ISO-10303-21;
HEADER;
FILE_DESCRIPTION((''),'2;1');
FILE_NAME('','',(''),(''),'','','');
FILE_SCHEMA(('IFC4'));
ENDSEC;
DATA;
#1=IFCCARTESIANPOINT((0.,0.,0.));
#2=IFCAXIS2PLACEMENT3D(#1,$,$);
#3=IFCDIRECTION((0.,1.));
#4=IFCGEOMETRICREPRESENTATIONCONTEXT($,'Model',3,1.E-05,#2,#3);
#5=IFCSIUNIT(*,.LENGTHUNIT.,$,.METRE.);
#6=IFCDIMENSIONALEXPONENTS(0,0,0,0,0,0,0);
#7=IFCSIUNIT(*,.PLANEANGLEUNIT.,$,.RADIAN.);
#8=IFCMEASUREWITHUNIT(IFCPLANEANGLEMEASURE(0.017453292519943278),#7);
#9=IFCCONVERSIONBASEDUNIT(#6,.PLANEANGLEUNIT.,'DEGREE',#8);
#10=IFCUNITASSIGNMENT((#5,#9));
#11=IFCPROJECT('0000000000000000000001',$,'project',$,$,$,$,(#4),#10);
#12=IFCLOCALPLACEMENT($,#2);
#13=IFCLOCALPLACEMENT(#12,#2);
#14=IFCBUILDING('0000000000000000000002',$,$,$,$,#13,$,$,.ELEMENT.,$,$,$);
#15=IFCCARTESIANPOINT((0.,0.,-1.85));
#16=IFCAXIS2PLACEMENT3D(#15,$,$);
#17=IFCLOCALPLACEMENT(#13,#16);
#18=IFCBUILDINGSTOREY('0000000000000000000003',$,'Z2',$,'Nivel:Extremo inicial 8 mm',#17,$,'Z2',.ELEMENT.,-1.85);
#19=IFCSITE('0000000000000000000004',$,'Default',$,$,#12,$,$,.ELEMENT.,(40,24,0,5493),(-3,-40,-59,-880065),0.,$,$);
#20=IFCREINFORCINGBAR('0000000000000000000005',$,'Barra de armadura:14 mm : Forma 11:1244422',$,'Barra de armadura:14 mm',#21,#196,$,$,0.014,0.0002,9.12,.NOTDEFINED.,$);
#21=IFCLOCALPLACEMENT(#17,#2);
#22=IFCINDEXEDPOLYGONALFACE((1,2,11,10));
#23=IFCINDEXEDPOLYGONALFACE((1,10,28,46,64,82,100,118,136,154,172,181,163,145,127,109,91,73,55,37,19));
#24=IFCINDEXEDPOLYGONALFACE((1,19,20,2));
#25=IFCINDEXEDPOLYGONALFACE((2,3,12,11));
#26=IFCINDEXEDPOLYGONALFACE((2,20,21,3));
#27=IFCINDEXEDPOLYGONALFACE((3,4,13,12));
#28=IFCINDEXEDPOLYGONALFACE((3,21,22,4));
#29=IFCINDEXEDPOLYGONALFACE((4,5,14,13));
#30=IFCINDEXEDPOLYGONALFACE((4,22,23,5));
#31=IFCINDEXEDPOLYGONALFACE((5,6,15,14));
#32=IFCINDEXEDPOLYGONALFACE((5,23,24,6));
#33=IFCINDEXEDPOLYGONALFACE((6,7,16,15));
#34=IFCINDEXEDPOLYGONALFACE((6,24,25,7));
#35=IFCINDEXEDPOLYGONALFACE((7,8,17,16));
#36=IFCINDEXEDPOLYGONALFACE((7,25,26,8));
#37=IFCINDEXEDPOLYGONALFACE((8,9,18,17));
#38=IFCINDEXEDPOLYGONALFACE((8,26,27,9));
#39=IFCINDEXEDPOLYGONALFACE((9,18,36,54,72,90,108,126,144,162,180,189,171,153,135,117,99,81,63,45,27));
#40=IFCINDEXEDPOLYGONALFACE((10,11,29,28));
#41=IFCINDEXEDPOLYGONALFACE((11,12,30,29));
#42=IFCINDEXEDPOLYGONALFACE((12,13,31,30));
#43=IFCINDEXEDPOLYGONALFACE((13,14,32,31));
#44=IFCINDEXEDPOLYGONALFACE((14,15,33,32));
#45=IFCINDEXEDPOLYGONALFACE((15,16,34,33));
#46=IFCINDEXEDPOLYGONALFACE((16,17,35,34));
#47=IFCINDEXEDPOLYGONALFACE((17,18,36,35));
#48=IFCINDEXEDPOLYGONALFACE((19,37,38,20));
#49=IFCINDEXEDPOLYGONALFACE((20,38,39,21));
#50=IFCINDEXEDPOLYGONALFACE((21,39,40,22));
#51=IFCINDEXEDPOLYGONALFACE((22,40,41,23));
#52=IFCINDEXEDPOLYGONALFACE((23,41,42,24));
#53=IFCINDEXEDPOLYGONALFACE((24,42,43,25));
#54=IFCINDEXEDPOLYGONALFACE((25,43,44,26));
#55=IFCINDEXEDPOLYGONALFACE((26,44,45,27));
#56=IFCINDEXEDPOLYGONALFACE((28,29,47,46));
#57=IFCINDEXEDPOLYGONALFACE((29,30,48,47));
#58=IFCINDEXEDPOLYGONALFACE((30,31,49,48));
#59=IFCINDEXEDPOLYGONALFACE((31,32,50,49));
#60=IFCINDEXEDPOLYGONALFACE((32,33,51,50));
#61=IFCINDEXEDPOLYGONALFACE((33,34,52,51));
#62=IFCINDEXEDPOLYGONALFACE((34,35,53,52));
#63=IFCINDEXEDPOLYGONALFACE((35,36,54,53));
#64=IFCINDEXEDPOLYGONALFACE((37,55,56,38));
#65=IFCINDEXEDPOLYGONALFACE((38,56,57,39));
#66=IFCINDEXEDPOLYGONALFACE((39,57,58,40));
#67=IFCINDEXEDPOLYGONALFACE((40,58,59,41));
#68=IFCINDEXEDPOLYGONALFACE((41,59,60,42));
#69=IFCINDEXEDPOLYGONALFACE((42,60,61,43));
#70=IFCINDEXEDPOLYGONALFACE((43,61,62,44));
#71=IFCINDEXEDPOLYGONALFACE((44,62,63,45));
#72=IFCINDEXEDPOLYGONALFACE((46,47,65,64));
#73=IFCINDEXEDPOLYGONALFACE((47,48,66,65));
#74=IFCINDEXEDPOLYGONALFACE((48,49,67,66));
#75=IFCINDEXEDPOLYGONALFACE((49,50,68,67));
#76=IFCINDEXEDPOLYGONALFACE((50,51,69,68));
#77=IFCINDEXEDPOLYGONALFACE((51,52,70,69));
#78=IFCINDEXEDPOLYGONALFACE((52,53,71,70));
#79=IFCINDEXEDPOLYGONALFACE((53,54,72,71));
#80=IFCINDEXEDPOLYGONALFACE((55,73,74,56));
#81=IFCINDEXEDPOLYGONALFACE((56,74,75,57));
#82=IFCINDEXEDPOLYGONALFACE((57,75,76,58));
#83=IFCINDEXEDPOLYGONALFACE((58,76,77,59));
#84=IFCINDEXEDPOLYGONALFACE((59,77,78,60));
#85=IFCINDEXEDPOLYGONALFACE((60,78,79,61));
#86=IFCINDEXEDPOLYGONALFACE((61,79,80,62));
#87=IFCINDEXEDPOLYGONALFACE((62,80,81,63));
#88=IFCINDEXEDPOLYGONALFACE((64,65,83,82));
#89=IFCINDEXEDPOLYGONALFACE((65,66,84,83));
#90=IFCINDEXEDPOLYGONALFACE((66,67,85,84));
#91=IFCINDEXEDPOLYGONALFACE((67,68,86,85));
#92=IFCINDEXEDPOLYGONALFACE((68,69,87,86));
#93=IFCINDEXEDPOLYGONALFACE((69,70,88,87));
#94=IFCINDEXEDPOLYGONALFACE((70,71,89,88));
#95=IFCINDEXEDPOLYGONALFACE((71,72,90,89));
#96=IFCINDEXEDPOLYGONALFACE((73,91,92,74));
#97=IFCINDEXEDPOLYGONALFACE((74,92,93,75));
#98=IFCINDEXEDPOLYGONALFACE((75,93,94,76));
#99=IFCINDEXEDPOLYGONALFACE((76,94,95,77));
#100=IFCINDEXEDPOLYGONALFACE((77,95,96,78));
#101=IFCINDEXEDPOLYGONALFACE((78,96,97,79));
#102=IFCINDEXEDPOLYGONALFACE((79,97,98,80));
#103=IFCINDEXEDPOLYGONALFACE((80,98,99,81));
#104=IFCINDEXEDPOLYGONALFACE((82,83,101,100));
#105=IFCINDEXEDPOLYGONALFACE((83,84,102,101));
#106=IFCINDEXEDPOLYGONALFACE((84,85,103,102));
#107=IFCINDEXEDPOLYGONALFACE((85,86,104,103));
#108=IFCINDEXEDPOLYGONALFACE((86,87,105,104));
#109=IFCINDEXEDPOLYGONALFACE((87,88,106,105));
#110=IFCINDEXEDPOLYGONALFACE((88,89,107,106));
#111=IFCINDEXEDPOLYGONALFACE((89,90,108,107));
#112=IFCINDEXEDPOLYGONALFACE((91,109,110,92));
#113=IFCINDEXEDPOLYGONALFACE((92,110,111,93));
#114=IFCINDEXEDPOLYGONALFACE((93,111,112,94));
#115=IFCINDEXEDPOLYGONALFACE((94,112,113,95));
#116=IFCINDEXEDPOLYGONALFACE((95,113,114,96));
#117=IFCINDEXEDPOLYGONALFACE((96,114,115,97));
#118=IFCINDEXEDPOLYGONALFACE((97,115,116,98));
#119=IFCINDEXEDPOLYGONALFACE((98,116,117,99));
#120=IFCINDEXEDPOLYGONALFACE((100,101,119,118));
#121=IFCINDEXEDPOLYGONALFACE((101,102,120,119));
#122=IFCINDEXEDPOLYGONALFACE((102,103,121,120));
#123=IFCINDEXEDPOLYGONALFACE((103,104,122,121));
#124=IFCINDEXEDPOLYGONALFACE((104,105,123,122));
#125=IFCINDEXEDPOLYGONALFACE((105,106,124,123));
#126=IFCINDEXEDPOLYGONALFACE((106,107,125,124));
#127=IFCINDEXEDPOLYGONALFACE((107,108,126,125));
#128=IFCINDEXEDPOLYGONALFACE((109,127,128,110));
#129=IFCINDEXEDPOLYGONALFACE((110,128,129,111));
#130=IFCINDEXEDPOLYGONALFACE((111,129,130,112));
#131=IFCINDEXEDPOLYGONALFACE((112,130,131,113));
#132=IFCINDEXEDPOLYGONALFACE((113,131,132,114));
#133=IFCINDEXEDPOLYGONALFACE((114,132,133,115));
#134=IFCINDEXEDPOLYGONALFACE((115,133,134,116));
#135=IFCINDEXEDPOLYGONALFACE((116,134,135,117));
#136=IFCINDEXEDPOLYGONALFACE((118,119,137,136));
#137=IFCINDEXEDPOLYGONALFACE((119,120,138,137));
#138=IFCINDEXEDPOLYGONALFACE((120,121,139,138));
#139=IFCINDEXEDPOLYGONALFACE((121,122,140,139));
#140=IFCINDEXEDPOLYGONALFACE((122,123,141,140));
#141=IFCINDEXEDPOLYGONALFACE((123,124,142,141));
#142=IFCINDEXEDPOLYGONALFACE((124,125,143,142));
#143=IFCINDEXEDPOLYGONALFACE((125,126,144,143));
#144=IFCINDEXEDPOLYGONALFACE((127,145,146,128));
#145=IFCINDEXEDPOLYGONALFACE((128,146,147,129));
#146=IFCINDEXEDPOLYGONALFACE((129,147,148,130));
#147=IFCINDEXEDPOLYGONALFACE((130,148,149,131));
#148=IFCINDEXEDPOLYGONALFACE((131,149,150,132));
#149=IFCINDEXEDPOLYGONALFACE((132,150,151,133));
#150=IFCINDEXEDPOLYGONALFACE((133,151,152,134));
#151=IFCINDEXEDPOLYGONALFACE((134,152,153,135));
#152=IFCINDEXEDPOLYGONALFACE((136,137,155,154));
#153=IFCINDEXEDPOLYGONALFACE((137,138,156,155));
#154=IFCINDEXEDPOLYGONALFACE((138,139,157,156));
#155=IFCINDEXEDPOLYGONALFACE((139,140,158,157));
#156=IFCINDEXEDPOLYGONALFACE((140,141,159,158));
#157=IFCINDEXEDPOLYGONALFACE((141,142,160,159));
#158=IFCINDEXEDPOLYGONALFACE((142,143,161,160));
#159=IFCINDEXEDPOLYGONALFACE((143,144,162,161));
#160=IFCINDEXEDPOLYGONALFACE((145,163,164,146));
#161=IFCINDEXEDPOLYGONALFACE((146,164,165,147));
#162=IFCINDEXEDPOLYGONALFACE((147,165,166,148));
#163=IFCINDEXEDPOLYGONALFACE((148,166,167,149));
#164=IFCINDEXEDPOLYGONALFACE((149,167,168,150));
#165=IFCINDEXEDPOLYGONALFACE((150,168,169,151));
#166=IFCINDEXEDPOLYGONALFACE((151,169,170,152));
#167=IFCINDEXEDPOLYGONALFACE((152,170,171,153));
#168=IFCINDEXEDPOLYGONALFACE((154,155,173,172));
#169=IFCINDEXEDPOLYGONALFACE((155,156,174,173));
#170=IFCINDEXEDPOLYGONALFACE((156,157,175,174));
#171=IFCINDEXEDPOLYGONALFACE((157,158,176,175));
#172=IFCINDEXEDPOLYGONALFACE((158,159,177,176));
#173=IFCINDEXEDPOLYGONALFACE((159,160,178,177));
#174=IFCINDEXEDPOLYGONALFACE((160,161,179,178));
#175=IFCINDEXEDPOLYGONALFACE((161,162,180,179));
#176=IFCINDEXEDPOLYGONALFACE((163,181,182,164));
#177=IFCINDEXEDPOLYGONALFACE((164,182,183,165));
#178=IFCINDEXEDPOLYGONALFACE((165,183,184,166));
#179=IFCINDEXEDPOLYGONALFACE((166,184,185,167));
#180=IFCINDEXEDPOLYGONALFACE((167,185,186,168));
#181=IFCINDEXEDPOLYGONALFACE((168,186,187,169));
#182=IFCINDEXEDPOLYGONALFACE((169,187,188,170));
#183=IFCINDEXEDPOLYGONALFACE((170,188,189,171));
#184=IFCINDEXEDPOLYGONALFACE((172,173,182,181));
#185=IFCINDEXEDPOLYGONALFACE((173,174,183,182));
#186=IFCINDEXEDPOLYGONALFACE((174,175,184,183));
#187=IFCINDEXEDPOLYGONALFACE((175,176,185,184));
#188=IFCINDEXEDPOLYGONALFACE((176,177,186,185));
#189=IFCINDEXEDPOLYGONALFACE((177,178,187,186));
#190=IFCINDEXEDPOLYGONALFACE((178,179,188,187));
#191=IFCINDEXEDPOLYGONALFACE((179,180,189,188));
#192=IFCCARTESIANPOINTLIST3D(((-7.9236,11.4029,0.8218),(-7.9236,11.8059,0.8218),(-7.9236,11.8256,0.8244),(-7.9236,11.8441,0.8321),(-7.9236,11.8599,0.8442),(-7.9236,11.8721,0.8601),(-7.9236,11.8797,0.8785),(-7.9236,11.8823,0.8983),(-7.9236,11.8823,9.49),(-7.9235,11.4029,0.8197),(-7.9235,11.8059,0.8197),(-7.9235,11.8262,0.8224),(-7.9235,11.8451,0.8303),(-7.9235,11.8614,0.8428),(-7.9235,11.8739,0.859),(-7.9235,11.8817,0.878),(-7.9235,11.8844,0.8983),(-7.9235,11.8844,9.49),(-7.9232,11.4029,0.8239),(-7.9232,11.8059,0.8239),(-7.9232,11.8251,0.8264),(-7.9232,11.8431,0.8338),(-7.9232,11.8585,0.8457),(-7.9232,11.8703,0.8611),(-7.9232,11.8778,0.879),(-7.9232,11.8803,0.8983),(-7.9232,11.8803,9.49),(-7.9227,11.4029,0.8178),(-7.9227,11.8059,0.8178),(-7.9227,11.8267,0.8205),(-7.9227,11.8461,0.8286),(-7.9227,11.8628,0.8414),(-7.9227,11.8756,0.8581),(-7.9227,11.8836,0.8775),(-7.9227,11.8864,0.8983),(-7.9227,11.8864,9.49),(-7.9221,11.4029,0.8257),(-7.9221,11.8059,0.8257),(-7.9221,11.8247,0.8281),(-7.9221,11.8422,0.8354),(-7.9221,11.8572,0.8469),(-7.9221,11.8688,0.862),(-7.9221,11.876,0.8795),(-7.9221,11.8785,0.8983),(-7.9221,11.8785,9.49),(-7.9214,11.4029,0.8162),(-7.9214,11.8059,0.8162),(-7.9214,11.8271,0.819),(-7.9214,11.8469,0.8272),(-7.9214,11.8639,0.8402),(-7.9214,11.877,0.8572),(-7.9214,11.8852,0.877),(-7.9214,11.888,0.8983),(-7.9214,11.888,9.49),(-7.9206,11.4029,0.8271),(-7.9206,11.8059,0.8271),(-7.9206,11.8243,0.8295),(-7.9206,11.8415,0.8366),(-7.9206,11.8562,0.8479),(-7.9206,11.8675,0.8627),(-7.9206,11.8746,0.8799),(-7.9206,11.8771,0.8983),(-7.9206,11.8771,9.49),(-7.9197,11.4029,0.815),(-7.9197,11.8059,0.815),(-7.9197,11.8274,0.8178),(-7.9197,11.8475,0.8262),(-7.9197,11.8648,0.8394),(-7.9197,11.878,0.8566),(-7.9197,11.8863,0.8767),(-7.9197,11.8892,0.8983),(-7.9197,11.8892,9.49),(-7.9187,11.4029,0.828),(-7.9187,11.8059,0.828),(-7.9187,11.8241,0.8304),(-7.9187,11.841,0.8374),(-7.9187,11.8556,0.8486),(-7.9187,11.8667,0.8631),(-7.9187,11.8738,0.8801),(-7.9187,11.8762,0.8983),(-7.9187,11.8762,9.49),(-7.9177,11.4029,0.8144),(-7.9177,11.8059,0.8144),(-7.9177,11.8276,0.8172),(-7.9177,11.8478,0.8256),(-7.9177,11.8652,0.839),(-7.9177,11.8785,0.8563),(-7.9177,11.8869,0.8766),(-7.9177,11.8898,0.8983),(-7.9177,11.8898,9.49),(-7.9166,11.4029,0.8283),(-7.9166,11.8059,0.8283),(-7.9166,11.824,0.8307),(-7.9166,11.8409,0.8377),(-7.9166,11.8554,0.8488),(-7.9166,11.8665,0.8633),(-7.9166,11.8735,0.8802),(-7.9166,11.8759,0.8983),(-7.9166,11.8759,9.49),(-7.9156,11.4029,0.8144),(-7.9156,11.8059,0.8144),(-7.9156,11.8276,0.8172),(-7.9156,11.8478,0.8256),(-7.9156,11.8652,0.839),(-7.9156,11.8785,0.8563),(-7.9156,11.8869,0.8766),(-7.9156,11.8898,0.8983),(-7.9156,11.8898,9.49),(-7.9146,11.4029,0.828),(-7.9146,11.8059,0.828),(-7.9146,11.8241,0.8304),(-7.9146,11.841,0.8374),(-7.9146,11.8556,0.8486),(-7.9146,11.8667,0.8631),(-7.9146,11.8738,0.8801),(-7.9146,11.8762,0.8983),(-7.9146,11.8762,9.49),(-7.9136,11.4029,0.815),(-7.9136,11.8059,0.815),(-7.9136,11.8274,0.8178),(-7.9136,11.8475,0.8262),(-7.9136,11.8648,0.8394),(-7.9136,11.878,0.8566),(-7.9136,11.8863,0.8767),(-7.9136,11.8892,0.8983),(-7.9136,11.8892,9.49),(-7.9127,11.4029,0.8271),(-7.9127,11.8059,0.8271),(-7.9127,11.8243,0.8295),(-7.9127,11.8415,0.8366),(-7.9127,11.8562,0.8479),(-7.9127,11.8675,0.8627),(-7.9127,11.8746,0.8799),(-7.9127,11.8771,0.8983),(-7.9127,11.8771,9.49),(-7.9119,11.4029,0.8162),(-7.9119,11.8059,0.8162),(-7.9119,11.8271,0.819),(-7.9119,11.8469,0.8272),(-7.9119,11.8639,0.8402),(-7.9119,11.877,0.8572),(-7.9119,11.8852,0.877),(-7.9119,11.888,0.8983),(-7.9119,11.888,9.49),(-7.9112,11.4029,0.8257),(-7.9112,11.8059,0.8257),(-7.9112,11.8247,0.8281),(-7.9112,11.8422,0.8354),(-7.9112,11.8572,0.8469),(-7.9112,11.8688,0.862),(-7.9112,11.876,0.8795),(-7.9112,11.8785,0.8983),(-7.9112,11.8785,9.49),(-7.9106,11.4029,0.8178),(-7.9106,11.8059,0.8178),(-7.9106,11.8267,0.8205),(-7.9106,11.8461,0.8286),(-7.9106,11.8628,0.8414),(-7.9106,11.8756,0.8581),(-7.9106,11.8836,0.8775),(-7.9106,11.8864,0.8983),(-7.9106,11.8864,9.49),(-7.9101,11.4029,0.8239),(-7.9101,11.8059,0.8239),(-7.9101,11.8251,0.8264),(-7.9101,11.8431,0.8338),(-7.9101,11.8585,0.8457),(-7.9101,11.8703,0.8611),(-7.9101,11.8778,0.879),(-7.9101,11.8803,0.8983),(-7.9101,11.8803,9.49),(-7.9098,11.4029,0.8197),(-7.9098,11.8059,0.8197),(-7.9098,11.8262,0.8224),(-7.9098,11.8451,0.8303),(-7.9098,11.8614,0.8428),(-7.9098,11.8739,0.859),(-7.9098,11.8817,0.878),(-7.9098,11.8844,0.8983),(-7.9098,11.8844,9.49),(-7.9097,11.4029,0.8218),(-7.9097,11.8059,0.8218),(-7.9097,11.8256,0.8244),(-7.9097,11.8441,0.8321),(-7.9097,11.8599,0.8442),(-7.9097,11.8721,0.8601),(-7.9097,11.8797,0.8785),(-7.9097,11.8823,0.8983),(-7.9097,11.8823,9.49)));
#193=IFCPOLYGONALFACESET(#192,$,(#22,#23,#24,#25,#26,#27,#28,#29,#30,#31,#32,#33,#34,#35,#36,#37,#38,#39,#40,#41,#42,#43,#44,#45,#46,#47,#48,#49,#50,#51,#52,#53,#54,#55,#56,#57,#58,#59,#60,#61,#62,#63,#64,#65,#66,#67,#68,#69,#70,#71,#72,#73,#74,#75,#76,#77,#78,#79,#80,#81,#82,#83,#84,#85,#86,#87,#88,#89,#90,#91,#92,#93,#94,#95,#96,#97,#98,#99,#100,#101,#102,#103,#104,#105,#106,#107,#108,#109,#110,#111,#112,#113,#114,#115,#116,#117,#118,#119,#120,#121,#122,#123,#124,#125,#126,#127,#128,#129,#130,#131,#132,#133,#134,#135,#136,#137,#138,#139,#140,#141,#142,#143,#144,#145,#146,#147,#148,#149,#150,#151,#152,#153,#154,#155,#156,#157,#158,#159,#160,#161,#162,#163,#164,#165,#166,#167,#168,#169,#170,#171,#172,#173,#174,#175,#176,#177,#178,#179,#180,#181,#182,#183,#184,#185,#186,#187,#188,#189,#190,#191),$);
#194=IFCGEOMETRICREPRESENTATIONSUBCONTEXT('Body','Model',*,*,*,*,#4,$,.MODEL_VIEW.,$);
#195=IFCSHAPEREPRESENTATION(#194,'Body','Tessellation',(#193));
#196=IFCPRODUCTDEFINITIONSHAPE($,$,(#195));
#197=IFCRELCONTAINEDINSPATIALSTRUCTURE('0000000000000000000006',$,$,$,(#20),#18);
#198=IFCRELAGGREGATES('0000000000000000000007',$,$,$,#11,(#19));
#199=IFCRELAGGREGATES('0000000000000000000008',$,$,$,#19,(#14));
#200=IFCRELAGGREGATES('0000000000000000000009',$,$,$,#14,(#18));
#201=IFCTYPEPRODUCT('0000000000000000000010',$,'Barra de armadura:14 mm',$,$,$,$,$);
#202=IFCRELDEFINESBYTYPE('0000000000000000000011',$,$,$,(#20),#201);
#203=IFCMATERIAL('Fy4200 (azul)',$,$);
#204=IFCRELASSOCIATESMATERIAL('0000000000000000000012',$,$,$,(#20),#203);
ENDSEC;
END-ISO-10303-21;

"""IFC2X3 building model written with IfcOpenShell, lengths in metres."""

from ifc_helpers import new_model, entity, si_unit, converted_unit, direction, frame, origin, place, context, subcontext, project, spatial, material, type_object, element, save


model = new_model("IFC2X3")

# Units and contexts
model_context = context("Model", 3, precision=1e-05, world=origin(), true_north=direction((0.0, 1.0)))
body_context = subcontext(model_context, "Body", "Model", "MODEL_VIEW")
ifc_project = project(units=[si_unit("LENGTHUNIT", "METRE"), converted_unit("PLANEANGLEUNIT", "DEGREE", entity("IfcPlaneAngleMeasure", 0.017453292519943278), si_unit("PLANEANGLEUNIT", "RADIAN"), dimensions=[0, 0, 0, 0, 0, 0, 0])], contexts=[model_context])

# Site, building, storey
site_placement = place(None, origin())
site = spatial("IfcSite", under=ifc_project, at=site_placement, Name="Default", CompositionType="ELEMENT", RefLatitude=(40, 24, 0, 5493), RefLongitude=(-3, -40, -59, -880065), RefElevation=0.0)
building_placement = place(site_placement, origin())
building = spatial("IfcBuilding", under=site, at=building_placement, CompositionType="ELEMENT")
storey_placement = place(building_placement, frame((0.0, 0.0, -1.85)))
storey = spatial("IfcBuildingStorey", under=building, at=storey_placement, Name="Z2", ObjectType="Nivel:Extremo inicial 8 mm", LongName="Z2", CompositionType="ELEMENT", Elevation=-1.85)

# Reinforcing bar
ifc_material_1 = material(Name="Fy4200 (azul)")
type_product_1 = type_object("IfcTypeProduct", Name="Barra de armadura:14 mm")
reinforcing_bar_1_placement = place(storey_placement, origin())
element("IfcReinforcingBar", 1, at=reinforcing_bar_1_placement, inside=storey, type_object=type_product_1, material=ifc_material_1, Name="Barra de armadura:14 mm : Forma 11:1244422", ObjectType="Barra de armadura:14 mm", BarLength=9.12, BarRole="NOTDEFINED", CrossSectionArea=0.0002, NominalDiameter=0.014, context=body_context, shape_type="AdvancedSweptSolid", body=[
    entity("IfcSweptDiskSolid", entity("IfcCompositeCurve", [entity("IfcCompositeCurveSegment", "CONTINUOUS", True, entity("IfcPolyline", [entity("IfcCartesianPoint", [-7.9166, 11.8829, 9.49]), entity("IfcCartesianPoint", [-7.9166, 11.8829, 0.8983])])), entity("IfcCompositeCurveSegment", "CONTINUOUS", True, entity("IfcTrimmedCurve", entity("IfcCircle", entity("IfcAxis2Placement3D", entity("IfcCartesianPoint", [-7.9166, 11.8059, 0.8983]), entity("IfcDirection", [-1.0, 0.0, 0.0]), entity("IfcDirection", [0.0, 0.0, -1.0])), 0.077), [entity("IfcParameterValue", 270.0)], [entity("IfcParameterValue", 360.0)], True, "PARAMETER")), entity("IfcCompositeCurveSegment", "CONTINUOUS", True, entity("IfcPolyline", [entity("IfcCartesianPoint", [-7.9166, 11.8059, 0.8213]), entity("IfcCartesianPoint", [-7.9166, 11.4029, 0.8213])]))], False), 0.007, None, 0.0, 92.0),
])

save(model, "model.ifc")
